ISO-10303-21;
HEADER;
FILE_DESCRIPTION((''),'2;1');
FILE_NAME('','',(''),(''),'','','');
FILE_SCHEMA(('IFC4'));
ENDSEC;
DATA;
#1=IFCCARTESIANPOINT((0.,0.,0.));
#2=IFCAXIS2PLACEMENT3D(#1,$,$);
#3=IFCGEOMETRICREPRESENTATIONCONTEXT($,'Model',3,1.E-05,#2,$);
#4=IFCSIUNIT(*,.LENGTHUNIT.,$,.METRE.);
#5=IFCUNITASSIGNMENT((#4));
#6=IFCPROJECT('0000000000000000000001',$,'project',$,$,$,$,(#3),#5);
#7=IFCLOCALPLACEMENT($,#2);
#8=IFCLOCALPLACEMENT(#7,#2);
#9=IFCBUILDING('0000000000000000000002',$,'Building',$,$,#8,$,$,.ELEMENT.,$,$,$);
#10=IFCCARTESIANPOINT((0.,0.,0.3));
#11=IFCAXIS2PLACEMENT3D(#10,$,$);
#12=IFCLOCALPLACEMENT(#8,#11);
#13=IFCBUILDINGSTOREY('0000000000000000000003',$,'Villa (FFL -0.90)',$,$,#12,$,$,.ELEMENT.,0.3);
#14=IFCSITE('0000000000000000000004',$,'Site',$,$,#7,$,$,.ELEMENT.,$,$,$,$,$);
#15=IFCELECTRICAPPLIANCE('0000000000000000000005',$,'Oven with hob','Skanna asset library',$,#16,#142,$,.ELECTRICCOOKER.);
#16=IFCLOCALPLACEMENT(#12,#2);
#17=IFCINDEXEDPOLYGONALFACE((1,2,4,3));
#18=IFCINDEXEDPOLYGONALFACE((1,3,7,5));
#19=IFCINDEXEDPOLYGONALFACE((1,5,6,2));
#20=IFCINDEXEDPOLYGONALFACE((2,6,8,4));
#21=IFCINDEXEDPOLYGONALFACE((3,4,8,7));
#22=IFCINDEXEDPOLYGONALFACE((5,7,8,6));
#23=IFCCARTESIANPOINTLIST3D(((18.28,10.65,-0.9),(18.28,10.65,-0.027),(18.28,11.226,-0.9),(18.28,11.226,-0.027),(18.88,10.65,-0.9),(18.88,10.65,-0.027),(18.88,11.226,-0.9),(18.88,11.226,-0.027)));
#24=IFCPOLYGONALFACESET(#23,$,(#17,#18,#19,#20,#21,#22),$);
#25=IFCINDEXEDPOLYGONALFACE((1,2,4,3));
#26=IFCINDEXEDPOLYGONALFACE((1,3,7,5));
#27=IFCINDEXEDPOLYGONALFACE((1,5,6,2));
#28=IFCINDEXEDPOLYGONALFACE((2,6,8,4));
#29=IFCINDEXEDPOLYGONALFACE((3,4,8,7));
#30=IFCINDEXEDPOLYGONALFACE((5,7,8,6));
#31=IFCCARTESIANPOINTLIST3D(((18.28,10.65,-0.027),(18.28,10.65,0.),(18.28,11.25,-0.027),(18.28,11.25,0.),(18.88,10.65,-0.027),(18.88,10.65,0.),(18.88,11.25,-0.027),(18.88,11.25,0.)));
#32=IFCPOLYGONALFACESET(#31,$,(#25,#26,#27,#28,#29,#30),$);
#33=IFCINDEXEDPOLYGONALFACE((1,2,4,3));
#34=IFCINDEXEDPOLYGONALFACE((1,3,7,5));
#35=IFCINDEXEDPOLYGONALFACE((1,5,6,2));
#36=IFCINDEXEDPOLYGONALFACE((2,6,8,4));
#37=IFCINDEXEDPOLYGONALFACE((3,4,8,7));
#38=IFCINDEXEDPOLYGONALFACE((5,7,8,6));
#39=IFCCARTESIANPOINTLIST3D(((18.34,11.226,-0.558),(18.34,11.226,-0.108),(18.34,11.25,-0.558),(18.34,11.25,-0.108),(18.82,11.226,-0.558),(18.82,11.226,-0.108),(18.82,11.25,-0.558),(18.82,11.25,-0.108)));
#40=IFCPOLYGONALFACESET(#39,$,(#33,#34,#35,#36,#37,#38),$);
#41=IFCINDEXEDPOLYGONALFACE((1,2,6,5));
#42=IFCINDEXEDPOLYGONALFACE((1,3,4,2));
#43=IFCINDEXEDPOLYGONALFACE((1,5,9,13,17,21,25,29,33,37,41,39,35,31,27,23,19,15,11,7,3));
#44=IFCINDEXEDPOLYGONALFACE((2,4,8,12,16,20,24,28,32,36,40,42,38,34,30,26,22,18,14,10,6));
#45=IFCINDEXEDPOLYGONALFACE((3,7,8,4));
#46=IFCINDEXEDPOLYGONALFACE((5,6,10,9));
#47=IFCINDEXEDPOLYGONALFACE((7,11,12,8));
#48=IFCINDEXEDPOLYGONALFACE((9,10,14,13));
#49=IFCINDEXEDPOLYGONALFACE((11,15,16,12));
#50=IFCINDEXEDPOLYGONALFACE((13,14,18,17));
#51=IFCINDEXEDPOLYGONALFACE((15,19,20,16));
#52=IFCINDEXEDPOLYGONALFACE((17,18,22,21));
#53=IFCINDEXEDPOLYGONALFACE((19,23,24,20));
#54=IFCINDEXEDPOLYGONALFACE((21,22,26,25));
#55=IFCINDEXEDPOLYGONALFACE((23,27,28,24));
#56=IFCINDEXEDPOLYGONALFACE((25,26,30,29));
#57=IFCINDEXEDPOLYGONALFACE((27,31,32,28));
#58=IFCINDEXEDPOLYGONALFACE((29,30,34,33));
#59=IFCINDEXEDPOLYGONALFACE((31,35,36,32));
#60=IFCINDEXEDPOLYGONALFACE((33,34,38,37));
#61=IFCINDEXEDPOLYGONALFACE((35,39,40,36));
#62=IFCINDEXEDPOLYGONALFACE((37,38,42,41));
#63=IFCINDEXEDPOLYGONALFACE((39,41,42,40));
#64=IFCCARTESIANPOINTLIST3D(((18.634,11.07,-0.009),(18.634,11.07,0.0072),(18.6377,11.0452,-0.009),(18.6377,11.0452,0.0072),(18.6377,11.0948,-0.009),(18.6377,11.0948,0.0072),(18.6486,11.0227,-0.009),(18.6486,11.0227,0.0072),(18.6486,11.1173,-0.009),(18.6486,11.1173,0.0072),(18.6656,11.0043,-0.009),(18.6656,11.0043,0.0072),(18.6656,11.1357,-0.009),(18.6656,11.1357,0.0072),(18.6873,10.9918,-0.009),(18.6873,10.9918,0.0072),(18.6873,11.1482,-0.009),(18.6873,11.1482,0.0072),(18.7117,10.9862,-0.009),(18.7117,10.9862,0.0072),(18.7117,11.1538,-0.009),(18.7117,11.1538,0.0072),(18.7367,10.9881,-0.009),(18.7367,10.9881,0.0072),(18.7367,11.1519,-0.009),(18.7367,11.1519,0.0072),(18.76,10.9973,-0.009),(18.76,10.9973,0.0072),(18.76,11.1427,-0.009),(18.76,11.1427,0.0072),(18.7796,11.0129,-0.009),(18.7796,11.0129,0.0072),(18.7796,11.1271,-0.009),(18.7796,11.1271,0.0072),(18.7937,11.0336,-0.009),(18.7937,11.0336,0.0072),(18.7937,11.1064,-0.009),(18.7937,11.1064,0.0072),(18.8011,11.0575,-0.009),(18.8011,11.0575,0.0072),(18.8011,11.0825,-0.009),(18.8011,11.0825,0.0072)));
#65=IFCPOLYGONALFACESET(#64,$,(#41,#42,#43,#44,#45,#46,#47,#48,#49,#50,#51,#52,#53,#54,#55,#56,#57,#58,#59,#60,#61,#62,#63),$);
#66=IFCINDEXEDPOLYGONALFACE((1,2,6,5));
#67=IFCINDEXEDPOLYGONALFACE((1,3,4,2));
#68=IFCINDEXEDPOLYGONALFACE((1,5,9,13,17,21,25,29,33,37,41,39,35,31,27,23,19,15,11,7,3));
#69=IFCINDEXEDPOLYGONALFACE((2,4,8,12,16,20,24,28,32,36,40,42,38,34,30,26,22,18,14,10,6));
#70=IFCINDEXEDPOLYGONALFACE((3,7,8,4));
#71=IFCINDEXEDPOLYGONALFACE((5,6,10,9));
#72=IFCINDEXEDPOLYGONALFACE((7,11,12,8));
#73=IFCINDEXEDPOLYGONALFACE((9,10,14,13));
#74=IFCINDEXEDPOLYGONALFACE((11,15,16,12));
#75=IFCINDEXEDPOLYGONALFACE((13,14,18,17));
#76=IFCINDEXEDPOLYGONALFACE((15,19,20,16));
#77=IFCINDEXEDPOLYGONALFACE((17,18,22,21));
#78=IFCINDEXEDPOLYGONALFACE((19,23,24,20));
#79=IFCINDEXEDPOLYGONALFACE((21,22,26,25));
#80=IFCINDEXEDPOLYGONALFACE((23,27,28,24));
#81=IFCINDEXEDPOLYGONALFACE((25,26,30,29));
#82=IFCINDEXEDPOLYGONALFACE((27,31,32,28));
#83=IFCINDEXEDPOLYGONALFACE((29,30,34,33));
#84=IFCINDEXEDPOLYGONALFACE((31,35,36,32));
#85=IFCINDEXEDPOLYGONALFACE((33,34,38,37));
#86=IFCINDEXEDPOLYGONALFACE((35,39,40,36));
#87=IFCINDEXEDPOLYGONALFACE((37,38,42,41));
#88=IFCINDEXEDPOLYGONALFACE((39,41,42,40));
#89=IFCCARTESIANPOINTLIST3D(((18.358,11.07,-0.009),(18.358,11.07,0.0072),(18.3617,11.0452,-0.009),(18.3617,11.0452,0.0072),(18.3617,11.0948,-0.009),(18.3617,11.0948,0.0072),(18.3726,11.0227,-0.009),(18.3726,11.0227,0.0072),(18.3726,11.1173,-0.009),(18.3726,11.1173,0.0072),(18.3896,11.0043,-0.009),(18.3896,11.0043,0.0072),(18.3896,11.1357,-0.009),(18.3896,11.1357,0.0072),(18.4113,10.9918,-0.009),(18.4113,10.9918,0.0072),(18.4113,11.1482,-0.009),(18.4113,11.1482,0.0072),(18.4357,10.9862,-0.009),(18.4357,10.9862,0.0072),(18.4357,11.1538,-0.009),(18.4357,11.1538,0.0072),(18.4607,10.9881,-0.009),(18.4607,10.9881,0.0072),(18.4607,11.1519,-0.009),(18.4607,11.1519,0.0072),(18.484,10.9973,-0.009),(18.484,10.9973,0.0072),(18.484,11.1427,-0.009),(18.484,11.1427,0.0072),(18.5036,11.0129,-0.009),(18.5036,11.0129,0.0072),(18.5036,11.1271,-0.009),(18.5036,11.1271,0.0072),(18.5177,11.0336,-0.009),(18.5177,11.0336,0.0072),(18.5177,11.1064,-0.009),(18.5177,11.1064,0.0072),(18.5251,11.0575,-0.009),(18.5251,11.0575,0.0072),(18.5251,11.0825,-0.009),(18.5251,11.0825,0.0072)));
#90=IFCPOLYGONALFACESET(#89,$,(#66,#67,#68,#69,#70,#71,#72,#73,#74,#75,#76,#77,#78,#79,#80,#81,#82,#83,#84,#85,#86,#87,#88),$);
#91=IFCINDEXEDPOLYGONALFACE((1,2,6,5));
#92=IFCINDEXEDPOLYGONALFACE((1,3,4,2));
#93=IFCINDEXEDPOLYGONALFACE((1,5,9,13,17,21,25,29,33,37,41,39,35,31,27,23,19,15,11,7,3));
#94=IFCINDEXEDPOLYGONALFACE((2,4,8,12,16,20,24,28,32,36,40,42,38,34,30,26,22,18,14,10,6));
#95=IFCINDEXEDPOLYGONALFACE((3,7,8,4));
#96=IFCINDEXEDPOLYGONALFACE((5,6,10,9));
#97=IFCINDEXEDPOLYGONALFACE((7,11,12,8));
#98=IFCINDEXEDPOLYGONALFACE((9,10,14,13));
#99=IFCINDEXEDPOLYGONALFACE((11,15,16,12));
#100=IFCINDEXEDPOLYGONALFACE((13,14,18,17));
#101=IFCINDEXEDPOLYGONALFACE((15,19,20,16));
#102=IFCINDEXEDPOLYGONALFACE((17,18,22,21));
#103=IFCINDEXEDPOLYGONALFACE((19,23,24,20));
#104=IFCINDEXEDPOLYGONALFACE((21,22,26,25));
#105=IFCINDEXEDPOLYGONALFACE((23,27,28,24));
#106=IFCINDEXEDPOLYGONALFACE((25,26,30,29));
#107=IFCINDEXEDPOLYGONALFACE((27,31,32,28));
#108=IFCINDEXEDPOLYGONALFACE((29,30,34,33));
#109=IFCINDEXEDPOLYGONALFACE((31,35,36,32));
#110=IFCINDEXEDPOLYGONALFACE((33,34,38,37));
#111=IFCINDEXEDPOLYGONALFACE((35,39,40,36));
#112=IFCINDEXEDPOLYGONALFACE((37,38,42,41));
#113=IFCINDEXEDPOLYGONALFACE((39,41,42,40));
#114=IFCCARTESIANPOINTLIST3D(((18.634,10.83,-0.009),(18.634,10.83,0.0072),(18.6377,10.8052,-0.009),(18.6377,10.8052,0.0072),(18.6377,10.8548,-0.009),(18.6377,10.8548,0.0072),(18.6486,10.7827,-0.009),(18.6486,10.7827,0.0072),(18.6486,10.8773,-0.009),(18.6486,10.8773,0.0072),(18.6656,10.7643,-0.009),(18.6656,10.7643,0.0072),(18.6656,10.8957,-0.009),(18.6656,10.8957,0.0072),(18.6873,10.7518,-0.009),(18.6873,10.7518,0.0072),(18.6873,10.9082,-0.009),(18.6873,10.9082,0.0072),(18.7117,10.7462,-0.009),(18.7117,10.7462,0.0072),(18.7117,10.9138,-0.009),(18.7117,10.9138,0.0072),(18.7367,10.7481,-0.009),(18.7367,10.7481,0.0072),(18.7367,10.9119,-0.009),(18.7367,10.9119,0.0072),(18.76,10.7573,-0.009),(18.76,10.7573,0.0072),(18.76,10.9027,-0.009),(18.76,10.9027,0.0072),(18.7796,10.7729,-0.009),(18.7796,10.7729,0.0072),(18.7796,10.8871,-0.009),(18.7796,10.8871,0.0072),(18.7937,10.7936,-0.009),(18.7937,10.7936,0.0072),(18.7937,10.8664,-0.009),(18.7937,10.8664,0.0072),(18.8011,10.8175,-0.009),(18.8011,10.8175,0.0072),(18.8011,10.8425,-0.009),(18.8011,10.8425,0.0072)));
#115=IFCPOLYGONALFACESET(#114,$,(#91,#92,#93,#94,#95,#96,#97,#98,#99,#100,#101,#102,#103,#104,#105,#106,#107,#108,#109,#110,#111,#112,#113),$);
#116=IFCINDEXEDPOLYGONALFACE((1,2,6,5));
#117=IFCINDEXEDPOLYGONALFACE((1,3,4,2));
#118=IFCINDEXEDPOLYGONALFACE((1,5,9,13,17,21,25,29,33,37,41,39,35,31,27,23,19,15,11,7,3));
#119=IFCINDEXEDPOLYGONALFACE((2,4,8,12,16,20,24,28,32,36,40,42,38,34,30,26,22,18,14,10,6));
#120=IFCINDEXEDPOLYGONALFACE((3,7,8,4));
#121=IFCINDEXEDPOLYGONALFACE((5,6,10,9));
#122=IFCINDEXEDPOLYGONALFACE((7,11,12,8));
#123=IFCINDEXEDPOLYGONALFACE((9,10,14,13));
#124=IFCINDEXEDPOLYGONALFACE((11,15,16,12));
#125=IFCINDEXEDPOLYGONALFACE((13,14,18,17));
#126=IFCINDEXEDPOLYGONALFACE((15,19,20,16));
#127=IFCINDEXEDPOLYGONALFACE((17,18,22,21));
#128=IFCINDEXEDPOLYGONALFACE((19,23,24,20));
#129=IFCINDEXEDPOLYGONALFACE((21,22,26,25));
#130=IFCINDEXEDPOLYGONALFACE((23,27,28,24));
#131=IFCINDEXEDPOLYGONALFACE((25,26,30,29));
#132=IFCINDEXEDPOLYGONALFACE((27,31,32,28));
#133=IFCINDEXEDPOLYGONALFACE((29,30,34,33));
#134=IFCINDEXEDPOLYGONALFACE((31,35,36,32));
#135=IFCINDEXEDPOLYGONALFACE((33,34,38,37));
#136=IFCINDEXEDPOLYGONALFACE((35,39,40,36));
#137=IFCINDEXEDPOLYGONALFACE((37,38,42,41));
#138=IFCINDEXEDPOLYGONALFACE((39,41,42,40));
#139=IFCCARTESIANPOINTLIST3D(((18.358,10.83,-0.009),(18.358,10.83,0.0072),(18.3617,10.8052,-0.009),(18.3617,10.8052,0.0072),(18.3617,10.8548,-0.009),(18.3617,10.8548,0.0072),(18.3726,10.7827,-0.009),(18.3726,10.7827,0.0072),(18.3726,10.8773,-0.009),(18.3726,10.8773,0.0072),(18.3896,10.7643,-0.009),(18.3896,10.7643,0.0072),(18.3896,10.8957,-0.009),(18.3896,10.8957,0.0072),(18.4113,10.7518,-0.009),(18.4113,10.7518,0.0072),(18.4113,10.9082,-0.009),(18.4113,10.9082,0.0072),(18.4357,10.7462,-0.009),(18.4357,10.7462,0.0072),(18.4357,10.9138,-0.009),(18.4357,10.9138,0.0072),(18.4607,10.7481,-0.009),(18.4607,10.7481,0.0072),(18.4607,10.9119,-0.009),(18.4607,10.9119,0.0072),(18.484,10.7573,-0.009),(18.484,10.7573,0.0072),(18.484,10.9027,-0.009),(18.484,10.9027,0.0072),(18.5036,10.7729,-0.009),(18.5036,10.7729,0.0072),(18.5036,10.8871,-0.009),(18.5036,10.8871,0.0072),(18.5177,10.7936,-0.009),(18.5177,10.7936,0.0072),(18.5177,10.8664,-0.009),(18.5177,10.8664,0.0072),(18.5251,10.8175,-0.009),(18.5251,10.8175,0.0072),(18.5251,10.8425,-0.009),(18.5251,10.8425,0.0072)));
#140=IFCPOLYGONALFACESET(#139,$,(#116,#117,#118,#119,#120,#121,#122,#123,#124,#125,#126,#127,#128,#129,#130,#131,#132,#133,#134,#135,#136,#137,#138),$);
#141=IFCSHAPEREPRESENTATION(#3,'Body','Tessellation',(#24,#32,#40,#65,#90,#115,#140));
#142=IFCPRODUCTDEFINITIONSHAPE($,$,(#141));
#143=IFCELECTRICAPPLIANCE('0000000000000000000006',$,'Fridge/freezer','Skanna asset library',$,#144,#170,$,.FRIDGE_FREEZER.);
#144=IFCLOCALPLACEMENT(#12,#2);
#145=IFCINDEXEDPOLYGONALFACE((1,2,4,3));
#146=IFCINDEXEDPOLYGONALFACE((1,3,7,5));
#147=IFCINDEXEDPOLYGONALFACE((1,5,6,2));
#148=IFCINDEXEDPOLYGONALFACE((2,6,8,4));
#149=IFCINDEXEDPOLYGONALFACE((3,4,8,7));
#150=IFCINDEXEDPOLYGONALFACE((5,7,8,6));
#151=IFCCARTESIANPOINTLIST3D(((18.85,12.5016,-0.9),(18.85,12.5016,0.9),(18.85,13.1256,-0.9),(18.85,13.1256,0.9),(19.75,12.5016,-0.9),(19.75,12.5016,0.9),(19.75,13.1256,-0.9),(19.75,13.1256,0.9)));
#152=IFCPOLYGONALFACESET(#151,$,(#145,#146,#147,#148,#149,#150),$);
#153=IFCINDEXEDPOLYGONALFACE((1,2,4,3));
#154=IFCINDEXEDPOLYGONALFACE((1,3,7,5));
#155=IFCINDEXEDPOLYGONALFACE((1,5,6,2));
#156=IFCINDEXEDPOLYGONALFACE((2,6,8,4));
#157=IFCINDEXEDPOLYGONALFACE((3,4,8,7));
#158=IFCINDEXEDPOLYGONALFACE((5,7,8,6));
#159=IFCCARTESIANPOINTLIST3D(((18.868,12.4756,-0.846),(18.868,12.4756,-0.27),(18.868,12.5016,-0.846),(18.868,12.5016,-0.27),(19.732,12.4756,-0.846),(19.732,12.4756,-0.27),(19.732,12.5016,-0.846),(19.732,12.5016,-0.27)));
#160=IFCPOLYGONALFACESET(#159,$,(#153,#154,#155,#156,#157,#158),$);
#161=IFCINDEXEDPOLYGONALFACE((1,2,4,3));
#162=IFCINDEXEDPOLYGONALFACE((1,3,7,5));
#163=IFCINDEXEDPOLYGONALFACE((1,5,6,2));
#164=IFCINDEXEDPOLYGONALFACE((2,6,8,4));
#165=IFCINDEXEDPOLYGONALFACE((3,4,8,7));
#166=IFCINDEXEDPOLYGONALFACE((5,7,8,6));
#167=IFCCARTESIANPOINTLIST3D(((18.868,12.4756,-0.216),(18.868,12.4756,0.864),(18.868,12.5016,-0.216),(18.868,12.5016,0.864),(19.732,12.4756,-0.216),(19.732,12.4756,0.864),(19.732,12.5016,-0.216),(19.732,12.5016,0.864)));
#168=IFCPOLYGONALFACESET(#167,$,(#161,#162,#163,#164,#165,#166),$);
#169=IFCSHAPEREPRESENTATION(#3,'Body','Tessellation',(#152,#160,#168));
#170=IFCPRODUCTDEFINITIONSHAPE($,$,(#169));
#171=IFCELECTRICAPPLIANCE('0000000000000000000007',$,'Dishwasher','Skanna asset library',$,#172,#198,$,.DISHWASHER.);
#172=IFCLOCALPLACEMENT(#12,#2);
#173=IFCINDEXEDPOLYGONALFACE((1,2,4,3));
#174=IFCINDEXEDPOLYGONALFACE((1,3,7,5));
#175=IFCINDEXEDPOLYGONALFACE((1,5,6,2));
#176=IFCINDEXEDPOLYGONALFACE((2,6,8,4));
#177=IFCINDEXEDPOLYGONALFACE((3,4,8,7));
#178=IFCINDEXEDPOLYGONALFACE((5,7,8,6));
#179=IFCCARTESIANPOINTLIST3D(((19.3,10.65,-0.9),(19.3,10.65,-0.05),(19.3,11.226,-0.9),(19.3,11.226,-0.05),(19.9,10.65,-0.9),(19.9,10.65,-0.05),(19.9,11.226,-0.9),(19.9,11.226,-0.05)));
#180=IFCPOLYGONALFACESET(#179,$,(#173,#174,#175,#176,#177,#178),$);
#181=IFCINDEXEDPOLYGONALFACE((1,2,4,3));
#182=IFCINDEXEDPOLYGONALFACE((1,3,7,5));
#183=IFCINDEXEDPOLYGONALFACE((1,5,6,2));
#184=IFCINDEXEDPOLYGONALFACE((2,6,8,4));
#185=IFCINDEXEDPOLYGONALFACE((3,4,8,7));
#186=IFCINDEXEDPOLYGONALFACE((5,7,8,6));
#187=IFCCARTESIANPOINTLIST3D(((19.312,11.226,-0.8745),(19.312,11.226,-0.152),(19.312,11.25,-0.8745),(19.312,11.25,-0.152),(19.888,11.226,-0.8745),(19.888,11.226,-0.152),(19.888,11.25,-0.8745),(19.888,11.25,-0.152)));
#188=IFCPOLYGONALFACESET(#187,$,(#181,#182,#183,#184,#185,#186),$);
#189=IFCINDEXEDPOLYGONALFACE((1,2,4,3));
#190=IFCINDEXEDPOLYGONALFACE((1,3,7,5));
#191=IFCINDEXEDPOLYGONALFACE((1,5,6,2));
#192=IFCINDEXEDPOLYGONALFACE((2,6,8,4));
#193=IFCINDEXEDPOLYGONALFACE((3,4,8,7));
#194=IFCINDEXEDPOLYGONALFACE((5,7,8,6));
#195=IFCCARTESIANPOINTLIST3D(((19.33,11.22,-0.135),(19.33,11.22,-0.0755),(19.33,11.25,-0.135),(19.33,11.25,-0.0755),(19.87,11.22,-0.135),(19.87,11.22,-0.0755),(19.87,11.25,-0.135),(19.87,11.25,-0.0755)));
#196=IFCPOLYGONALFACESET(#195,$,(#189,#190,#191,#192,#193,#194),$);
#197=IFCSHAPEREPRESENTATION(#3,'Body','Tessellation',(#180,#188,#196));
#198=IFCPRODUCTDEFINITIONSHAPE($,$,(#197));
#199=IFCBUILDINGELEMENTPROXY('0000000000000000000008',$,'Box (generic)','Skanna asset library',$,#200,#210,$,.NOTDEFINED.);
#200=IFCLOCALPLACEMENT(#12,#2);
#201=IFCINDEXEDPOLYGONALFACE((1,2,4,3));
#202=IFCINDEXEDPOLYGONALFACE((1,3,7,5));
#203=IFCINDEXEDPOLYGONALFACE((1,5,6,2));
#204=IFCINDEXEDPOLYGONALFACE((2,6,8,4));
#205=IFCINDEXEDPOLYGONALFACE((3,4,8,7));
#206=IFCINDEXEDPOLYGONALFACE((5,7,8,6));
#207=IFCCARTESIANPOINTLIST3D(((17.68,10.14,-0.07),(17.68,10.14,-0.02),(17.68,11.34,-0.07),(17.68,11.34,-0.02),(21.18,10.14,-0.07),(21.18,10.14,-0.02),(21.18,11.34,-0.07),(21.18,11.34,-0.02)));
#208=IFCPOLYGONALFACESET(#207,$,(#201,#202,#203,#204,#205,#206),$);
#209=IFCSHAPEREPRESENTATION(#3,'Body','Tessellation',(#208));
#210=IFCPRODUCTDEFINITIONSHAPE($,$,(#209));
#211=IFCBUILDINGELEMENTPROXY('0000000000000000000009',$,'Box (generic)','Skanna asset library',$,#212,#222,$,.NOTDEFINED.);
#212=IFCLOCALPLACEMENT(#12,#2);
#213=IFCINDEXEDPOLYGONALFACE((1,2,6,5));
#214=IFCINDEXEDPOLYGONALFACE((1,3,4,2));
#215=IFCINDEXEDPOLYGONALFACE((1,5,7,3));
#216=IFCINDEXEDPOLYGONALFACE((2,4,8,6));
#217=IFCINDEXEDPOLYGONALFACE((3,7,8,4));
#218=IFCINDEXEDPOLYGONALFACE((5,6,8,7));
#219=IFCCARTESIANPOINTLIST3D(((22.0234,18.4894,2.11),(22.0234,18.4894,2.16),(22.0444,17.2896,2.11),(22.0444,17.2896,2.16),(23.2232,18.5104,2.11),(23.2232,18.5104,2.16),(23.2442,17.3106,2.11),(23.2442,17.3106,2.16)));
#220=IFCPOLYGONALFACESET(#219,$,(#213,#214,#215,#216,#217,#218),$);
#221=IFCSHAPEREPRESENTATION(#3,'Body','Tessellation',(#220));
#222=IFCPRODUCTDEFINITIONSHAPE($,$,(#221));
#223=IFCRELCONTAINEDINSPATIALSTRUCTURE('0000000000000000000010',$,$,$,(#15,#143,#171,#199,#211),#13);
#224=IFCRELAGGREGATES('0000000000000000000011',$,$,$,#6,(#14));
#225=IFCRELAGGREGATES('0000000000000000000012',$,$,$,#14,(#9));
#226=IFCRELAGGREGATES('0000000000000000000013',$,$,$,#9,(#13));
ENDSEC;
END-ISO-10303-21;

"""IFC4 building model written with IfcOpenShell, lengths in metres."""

from ifc_helpers import new_model, si_unit, frame, frame_2d, origin, origin_2d, place, context, project, spatial, rectangle, circle, extrude, element, save


model = new_model("IFC4")

# Units and contexts
model_context = context("Model", 3, precision=1e-05, world=origin())
ifc_project = project(units=[si_unit("LENGTHUNIT", "METRE")], contexts=[model_context])

# Site, building, storey
site_placement = place(None, origin())
site = spatial("IfcSite", under=ifc_project, at=site_placement, Name="Site", CompositionType="ELEMENT")
building_placement = place(site_placement, origin())
building = spatial("IfcBuilding", under=site, at=building_placement, Name="Building", CompositionType="ELEMENT")
storey_placement = place(building_placement, frame((0.0, 0.0, 0.3)))
storey = spatial("IfcBuildingStorey", under=building, at=storey_placement, Name="Villa (FFL -0.90)", CompositionType="ELEMENT", Elevation=0.3)

# Electric appliances
electric_appliance_1_placement = place(storey_placement, frame((18.58, 10.95, -0.9), z_axis=(0.0, 0.0, 1.0), x_axis=(-1.0, 0.0, 0.0)))
element("IfcElectricAppliance", 1, at=electric_appliance_1_placement, inside=storey, Name="Oven with hob", Description="Skanna asset library", PredefinedType="ELECTRICCOOKER", context=model_context, shape_type="SweptSolid", body=[
    extrude(rectangle(XDim=0.6, YDim=0.576, at=frame_2d((0.0, 0.012))), origin(), (0.0, 0.0, 1.0), 0.873),
    extrude(rectangle(XDim=0.6, YDim=0.6, at=origin_2d()), frame((0.0, 0.0, 0.873)), (0.0, 0.0, 1.0), 0.027),
    extrude(rectangle(XDim=0.48, YDim=0.024, at=frame_2d((0.0, -0.288))), frame((0.0, 0.0, 0.342)), (0.0, 0.0, 1.0), 0.45),
    extrude(circle(Radius=0.084, at=frame_2d((-0.138, -0.12))), frame((0.0, 0.0, 0.891)), (0.0, 0.0, 1.0), 0.0162),
    extrude(circle(Radius=0.084, at=frame_2d((0.138, -0.12))), frame((0.0, 0.0, 0.891)), (0.0, 0.0, 1.0), 0.0162),
    extrude(circle(Radius=0.084, at=frame_2d((-0.138, 0.12))), frame((0.0, 0.0, 0.891)), (0.0, 0.0, 1.0), 0.0162),
    extrude(circle(Radius=0.084, at=frame_2d((0.138, 0.12))), frame((0.0, 0.0, 0.891)), (0.0, 0.0, 1.0), 0.0162),
])
electric_appliance_2_placement = place(storey_placement, frame((19.3, 12.8006, -0.9), z_axis=(0.0, 0.0, 1.0), x_axis=(1.0, 0.0, 0.0)))
element("IfcElectricAppliance", 2, at=electric_appliance_2_placement, inside=storey, Name="Fridge/freezer", Description="Skanna asset library", PredefinedType="FRIDGE_FREEZER", context=model_context, shape_type="SweptSolid", body=[
    extrude(rectangle(XDim=0.9, YDim=0.624, at=frame_2d((0.0, 0.013))), origin(), (0.0, 0.0, 1.0), 1.8),
    extrude(rectangle(XDim=0.864, YDim=0.026, at=frame_2d((0.0, -0.312))), frame((0.0, 0.0, 0.054)), (0.0, 0.0, 1.0), 0.576),
    extrude(rectangle(XDim=0.864, YDim=0.026, at=frame_2d((0.0, -0.312))), frame((0.0, 0.0, 0.684)), (0.0, 0.0, 1.0), 1.08),
])
electric_appliance_3_placement = place(storey_placement, frame((19.6, 10.95, -0.9), z_axis=(0.0, 0.0, 1.0), x_axis=(-1.0, 0.0, 0.0)))
element("IfcElectricAppliance", 3, at=electric_appliance_3_placement, inside=storey, Name="Dishwasher", Description="Skanna asset library", PredefinedType="DISHWASHER", context=model_context, shape_type="SweptSolid", body=[
    extrude(rectangle(XDim=0.6, YDim=0.576, at=frame_2d((0.0, 0.012))), origin(), (0.0, 0.0, 1.0), 0.85),
    extrude(rectangle(XDim=0.576, YDim=0.024, at=frame_2d((0.0, -0.288))), frame((0.0, 0.0, 0.0255)), (0.0, 0.0, 1.0), 0.7225),
    extrude(rectangle(XDim=0.54, YDim=0.03, at=frame_2d((0.0, -0.285))), frame((0.0, 0.0, 0.765)), (0.0, 0.0, 1.0), 0.0595),
])

# Building element proxies
proxy_1_placement = place(storey_placement, frame((19.43, 10.74, -0.07), z_axis=(0.0, 0.0, 1.0), x_axis=(1.0, 0.0, 0.0)))
element("IfcBuildingElementProxy", 4, at=proxy_1_placement, inside=storey, Name="Box (generic)", Description="Skanna asset library", PredefinedType="NOTDEFINED", context=model_context, shape_type="SweptSolid", body=[
    extrude(rectangle(XDim=3.5, YDim=1.2, at=origin_2d()), origin(), (0.0, 0.0, 1.0), 0.05),
])
proxy_2_placement = place(storey_placement, frame((22.6338, 17.9, 2.11), z_axis=(0.0, 0.0, 1.0), x_axis=(0.999848, 0.017452, 0.0)))
element("IfcBuildingElementProxy", 5, at=proxy_2_placement, inside=storey, Name="Box (generic)", Description="Skanna asset library", PredefinedType="NOTDEFINED", context=model_context, shape_type="SweptSolid", body=[
    extrude(rectangle(XDim=1.2, YDim=1.2, at=origin_2d()), origin(), (0.0, 0.0, 1.0), 0.05),
])

save(model, "model.ifc")
